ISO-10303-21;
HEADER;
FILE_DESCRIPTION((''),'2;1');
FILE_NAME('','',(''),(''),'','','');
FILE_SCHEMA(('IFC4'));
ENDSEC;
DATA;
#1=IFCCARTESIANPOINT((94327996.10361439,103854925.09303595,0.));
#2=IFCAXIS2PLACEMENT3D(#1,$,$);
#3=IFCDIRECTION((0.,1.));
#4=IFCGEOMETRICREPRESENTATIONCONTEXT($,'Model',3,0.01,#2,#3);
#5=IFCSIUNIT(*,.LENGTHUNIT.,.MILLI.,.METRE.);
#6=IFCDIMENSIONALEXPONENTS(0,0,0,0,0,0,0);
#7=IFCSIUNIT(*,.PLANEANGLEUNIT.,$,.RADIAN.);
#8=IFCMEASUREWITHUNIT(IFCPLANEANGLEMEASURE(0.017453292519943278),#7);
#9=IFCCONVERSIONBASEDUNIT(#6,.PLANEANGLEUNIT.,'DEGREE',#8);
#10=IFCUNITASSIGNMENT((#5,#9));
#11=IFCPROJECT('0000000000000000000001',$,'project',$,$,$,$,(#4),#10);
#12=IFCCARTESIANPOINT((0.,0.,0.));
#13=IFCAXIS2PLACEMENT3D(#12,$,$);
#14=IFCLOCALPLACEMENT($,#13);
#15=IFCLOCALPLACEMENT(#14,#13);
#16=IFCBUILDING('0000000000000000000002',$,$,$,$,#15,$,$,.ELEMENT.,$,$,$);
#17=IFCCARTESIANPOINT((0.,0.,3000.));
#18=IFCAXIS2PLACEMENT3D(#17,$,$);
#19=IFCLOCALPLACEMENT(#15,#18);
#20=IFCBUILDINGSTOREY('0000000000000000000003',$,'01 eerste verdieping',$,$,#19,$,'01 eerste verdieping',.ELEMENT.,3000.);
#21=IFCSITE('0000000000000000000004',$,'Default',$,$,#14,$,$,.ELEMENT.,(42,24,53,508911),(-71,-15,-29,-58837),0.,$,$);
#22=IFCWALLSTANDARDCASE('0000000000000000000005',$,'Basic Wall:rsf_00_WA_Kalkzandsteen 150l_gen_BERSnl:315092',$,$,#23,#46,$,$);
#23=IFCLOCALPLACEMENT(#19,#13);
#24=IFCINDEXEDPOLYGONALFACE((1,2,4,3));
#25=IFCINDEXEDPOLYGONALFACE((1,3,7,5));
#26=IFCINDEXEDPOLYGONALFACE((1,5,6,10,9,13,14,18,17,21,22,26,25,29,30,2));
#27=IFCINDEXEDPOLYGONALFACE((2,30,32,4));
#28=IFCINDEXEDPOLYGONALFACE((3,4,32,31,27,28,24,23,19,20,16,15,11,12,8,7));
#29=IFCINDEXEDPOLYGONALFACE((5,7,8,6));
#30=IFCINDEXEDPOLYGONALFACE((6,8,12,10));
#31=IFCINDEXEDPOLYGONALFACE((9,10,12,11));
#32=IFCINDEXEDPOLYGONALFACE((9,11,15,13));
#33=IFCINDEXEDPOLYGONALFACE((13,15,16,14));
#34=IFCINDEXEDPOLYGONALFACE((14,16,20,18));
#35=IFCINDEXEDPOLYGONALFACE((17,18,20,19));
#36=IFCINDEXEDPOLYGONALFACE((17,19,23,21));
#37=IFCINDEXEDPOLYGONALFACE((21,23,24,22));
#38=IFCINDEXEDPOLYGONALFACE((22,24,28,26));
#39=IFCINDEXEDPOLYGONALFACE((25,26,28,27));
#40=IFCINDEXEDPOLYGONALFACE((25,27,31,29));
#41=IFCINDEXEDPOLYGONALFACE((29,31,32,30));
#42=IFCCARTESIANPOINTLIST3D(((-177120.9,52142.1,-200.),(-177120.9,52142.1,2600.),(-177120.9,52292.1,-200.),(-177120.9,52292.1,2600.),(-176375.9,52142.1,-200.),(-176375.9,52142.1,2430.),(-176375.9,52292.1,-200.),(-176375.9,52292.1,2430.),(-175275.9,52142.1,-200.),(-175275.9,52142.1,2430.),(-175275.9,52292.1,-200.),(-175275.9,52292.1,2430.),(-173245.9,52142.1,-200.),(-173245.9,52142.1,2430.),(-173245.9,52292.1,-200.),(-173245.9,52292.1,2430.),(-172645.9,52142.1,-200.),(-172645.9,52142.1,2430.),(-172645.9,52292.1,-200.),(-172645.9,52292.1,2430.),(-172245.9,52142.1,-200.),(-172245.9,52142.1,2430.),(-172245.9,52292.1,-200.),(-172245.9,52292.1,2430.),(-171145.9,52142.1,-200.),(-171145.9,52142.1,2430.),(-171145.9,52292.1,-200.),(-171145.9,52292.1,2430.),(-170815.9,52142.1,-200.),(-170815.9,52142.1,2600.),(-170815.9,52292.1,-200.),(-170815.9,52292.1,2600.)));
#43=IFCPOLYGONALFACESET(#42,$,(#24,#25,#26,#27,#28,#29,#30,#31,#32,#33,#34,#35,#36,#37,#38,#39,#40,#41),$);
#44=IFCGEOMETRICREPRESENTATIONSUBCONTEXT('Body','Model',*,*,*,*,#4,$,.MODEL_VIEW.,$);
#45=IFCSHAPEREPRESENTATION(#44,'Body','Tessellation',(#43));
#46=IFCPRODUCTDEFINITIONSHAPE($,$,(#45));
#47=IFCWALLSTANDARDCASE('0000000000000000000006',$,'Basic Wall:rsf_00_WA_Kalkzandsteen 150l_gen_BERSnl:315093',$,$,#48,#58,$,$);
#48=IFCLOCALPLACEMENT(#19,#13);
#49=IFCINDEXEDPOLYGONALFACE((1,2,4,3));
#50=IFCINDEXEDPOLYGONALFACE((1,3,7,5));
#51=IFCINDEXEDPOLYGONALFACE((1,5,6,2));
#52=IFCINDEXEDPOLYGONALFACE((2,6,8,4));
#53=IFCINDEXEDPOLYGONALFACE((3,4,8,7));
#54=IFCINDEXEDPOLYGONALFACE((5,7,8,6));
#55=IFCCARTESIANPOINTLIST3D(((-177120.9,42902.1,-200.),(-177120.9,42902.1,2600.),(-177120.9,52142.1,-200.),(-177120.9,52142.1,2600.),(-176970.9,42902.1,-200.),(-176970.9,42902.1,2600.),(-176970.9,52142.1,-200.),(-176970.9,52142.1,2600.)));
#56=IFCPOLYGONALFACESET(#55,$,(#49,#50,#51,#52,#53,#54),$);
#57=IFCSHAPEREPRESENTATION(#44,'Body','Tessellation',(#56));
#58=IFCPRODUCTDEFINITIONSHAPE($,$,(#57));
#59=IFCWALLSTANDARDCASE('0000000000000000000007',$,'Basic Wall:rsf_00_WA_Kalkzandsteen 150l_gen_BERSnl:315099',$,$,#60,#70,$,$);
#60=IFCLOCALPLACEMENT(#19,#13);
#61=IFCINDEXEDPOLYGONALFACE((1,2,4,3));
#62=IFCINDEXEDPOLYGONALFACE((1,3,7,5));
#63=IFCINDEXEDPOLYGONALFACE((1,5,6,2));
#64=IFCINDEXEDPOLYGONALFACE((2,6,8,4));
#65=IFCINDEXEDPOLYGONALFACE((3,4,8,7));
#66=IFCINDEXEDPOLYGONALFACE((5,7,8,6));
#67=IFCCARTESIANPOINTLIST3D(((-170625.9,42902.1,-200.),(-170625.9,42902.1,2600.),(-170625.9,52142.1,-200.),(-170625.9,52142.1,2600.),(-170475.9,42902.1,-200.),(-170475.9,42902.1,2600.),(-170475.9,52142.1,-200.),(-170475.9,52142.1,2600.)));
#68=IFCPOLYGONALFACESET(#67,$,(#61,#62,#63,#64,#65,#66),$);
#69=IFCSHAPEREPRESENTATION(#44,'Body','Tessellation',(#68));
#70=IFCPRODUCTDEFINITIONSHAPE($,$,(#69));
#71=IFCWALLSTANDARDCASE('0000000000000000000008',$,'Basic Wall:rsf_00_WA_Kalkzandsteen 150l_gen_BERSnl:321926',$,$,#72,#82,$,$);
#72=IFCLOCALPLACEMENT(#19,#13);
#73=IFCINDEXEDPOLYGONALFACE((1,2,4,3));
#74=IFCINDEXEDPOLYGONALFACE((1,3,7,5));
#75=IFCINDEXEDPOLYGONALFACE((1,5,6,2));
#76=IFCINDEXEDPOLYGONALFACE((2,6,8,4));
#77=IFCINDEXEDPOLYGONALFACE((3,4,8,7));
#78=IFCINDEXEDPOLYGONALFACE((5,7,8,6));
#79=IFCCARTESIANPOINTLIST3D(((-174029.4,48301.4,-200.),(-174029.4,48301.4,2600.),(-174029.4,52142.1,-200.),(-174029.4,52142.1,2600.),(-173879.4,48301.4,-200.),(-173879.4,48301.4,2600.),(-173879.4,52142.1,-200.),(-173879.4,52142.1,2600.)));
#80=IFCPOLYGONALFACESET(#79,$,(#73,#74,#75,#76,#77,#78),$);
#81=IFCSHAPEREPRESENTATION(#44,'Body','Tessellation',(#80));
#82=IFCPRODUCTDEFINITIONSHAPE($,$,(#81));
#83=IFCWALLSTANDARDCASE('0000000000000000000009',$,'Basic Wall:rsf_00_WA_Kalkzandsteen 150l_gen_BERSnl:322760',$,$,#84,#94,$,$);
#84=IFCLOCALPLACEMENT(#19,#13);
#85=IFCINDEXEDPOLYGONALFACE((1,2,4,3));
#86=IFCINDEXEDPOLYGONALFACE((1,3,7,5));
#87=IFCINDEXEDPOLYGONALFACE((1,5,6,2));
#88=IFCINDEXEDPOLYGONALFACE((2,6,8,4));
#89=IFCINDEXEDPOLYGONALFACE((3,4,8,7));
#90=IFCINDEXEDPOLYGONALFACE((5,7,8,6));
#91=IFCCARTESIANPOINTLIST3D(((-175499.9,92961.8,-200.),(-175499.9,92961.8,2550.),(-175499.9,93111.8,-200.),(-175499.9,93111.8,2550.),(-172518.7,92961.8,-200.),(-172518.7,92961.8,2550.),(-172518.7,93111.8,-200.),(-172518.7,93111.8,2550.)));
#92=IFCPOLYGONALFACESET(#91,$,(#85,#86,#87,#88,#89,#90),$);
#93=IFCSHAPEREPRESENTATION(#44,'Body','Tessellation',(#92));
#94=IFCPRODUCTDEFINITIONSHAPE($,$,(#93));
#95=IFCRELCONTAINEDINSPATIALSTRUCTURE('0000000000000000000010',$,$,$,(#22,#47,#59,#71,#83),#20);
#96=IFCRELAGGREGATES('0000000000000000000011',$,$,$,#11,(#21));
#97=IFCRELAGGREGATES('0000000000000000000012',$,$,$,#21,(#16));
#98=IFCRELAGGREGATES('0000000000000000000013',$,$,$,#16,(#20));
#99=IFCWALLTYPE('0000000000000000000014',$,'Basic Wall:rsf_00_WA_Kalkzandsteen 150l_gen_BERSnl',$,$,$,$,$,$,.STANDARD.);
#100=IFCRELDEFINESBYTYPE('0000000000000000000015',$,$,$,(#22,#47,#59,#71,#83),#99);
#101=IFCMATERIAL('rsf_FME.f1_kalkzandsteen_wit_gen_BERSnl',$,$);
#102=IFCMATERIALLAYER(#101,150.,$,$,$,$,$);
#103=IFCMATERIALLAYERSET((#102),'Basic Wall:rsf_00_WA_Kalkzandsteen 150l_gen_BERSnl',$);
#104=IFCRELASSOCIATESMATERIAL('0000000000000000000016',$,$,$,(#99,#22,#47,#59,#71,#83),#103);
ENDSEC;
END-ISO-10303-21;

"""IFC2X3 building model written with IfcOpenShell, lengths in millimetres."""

from ifc_helpers import new_model, entity, si_unit, converted_unit, direction, frame, frame_2d, origin, place, context, subcontext, project, spatial, polyline, rectangle, extrude, clip, bounded_halfspace, material, layer, layer_set, layer_usage, type_object, element, save


model = new_model("IFC2X3")

# Units and contexts
model_context = context("Model", 3, precision=0.01, world=frame((94327996.10361439, 103854925.09303595, 0.0)), true_north=direction((0.0, 1.0)))
body_context = subcontext(model_context, "Body", "Model", "MODEL_VIEW")
ifc_project = project(units=[si_unit("LENGTHUNIT", "METRE", prefix="MILLI"), converted_unit("PLANEANGLEUNIT", "DEGREE", entity("IfcPlaneAngleMeasure", 0.017453292519943278), si_unit("PLANEANGLEUNIT", "RADIAN"), dimensions=[0, 0, 0, 0, 0, 0, 0])], contexts=[model_context])

# Site, building, storey
site_placement = place(None, origin())
site = spatial("IfcSite", under=ifc_project, at=site_placement, Name="Default", CompositionType="ELEMENT", RefLatitude=(42, 24, 53, 508911), RefLongitude=(-71, -15, -29, -58837), RefElevation=0.0)
building_placement = place(site_placement, origin())
building = spatial("IfcBuilding", under=site, at=building_placement, CompositionType="ELEMENT")
storey_placement = place(building_placement, frame((0.0, 0.0, 3000.0)))
storey = spatial("IfcBuildingStorey", under=building, at=storey_placement, Name="01 eerste verdieping", LongName="01 eerste verdieping", CompositionType="ELEMENT", Elevation=3000.0)

# Shared definitions
ifc_material = material(Name="rsf_FME.f1_kalkzandsteen_wit_gen_BERSnl")
ifc_layer = layer(ifc_material, 150.0)
ifc_layer_set = layer_set([ifc_layer], Name="Basic Wall:rsf_00_WA_Kalkzandsteen 150l_gen_BERSnl")
wall_type = type_object("IfcWallType", Name="Basic Wall:rsf_00_WA_Kalkzandsteen 150l_gen_BERSnl", PredefinedType="STANDARD", material=ifc_layer_set)

# Wall, openings
ifc_layer_usage_1 = layer_usage(ifc_layer_set, "AXIS2", "NEGATIVE", 75.0)
wall_1_placement = place(storey_placement, frame((-170815.9, 52217.1, -200.0), z_axis=(0.0, 0.0, 1.0), x_axis=(-1.0, 0.0, 0.0)))
wall_1 = element("IfcWallStandardCase", 1, at=wall_1_placement, inside=storey, type_object=wall_type, material=ifc_layer_usage_1, Name="Basic Wall:rsf_00_WA_Kalkzandsteen 150l_gen_BERSnl:315092", context=body_context, shape_type="Clipping", body=[
    clip(extrude(rectangle(XDim=6305.0, YDim=150.0, at=frame_2d((3152.5, 0.0), x_axis=(-1.0, 0.0))), origin(), (0.0, 0.0, 1.0), 2800.0), bounded_halfspace(frame((0.0, -75.0, 2800.0), z_axis=(0.0, 0.0, -1.0), x_axis=(0.0, -1.0, 0.0)), True, frame((0.0, -75.0, 2800.0)), polyline([(0.0, 0.0), (6305.0, 0.0), (6305.0, 150.0), (6155.0, 150.0), (3213.5, 150.0), (3063.5, 150.0), (0.0, 150.0), (0.0, 0.0)]))),
])
opening_1_placement = place(wall_1_placement, frame((-170815.9, 52217.1, 200.0), z_axis=(0.0, 0.0, 1.0), x_axis=(-1.0, 0.0, 0.0)))
element("IfcOpeningElement", 2, at=opening_1_placement, cuts=wall_1, ObjectType="Opening", context=body_context, shape_type="SweptSolid", body=[
    extrude(rectangle(XDim=2630.0, YDim=1100.0, at=frame_2d((0.0, 0.0), x_axis=(0.0, 1.0))), frame((-171695.9, 53816.1, 1115.0), z_axis=(0.0, -1.0, 0.0), x_axis=(1.0, 0.0, 0.0)), (0.0, 0.0, 1.0), 3048.0),
])
opening_2_placement = place(wall_1_placement, frame((-170815.9, 52217.1, 200.0), z_axis=(0.0, 0.0, 1.0), x_axis=(-1.0, 0.0, 0.0)))
element("IfcOpeningElement", 3, at=opening_2_placement, cuts=wall_1, ObjectType="Opening", context=body_context, shape_type="SweptSolid", body=[
    extrude(rectangle(XDim=2630.0, YDim=1100.0, at=frame_2d((0.0, 0.0), x_axis=(1.0, 0.0))), frame((-175825.9, 53666.1, 1115.0), z_axis=(0.0, -1.0, 0.0), x_axis=(0.0, 0.0, 1.0)), (0.0, 0.0, 1.0), 3048.0),
])
opening_3_placement = place(wall_1_placement, frame((-170815.9, 52217.1, 200.0), z_axis=(0.0, 0.0, 1.0), x_axis=(-1.0, 0.0, 0.0)))
element("IfcOpeningElement", 4, at=opening_3_placement, cuts=wall_1, ObjectType="Opening", context=body_context, shape_type="SweptSolid", body=[
    extrude(rectangle(XDim=2630.0, YDim=600.0, at=frame_2d((0.0, 0.0), x_axis=(0.0, 1.0))), frame((-172945.9, 53816.1, 1115.0), z_axis=(0.0, -1.0, 0.0), x_axis=(1.0, 0.0, 0.0)), (0.0, 0.0, 1.0), 3048.0),
])

# Walls
ifc_layer_usage_2 = layer_usage(ifc_layer_set, "AXIS2", "NEGATIVE", 75.0)
wall_2_placement = place(storey_placement, frame((-177045.9, 52142.1, -200.0), z_axis=(0.0, 0.0, 1.0), x_axis=(0.0, -1.0, 0.0)))
element("IfcWallStandardCase", 5, at=wall_2_placement, inside=storey, type_object=wall_type, material=ifc_layer_usage_2, Name="Basic Wall:rsf_00_WA_Kalkzandsteen 150l_gen_BERSnl:315093", context=body_context, shape_type="Clipping", body=[
    clip(extrude(rectangle(XDim=9240.0, YDim=150.0, at=frame_2d((4620.0, 0.0), x_axis=(-1.0, 0.0))), origin(), (0.0, 0.0, 1.0), 2800.0), bounded_halfspace(frame((0.0, -75.0, 2800.0), z_axis=(0.0, 0.0, -1.0), x_axis=(-1.0, 0.0, 0.0)), True, frame((0.0, -75.0, 2800.0)), polyline([(0.0, 0.0), (850.0, 0.0), (9240.0, 0.0), (9240.0, 150.0), (0.0, 150.0), (0.0, 0.0)]))),
])
ifc_layer_usage_3 = layer_usage(ifc_layer_set, "AXIS2", "NEGATIVE", 75.0)
wall_3_placement = place(storey_placement, frame((-170550.9, 52142.1, -200.0), z_axis=(0.0, 0.0, 1.0), x_axis=(0.0, -1.0, 0.0)))
element("IfcWallStandardCase", 6, at=wall_3_placement, inside=storey, type_object=wall_type, material=ifc_layer_usage_3, Name="Basic Wall:rsf_00_WA_Kalkzandsteen 150l_gen_BERSnl:315099", context=body_context, shape_type="Clipping", body=[
    clip(extrude(rectangle(XDim=9240.0, YDim=150.0, at=frame_2d((4620.0, 0.0), x_axis=(-1.0, 0.0))), origin(), (0.0, 0.0, 1.0), 2800.0), bounded_halfspace(frame((0.0, -75.0, 2800.0), z_axis=(0.0, 0.0, -1.0), x_axis=(-1.0, 0.0, 0.0)), True, frame((0.0, -75.0, 2800.0)), polyline([(0.0, 0.0), (9240.0, 0.0), (9240.0, 150.0), (0.0, 150.0), (0.0, 0.0)]))),
])
ifc_layer_usage_4 = layer_usage(ifc_layer_set, "AXIS2", "NEGATIVE", 75.0)
wall_4_placement = place(storey_placement, frame((-173954.4, 52142.1, -200.0), z_axis=(0.0, 0.0, 1.0), x_axis=(0.0, -1.0, 0.0)))
element("IfcWallStandardCase", 7, at=wall_4_placement, inside=storey, type_object=wall_type, material=ifc_layer_usage_4, Name="Basic Wall:rsf_00_WA_Kalkzandsteen 150l_gen_BERSnl:321926", context=body_context, shape_type="SweptSolid", body=[
    extrude(rectangle(XDim=3840.6, YDim=150.0, at=frame_2d((1920.3, 0.0), x_axis=(-1.0, 0.0))), origin(), (0.0, 0.0, 1.0), 2800.0),
])
ifc_layer_usage_5 = layer_usage(ifc_layer_set, "AXIS2", "POSITIVE", -75.0)
wall_5_placement = place(storey_placement, frame((-172518.7, 93036.8, -200.0), z_axis=(0.0, 0.0, 1.0), x_axis=(-1.0, 0.0, 0.0)))
element("IfcWallStandardCase", 8, at=wall_5_placement, inside=storey, type_object=wall_type, material=ifc_layer_usage_5, Name="Basic Wall:rsf_00_WA_Kalkzandsteen 150l_gen_BERSnl:322760", context=body_context, shape_type="Clipping", body=[
    clip(extrude(rectangle(XDim=2981.2, YDim=150.0, at=frame_2d((1490.6, 0.0), x_axis=(-1.0, 0.0))), origin(), (0.0, 0.0, 1.0), 2750.0), bounded_halfspace(frame((0.0, -75.0, 2750.0), z_axis=(0.0, 0.0, -1.0), x_axis=(0.0, -1.0, 0.0)), True, frame((0.0, -75.0, 2750.0)), polyline([(0.0, 0.0), (2981.2, 0.0), (2981.2, 150.0), (0.0, 150.0), (0.0, 0.0)]))),
])

save(model, "model.ifc")
